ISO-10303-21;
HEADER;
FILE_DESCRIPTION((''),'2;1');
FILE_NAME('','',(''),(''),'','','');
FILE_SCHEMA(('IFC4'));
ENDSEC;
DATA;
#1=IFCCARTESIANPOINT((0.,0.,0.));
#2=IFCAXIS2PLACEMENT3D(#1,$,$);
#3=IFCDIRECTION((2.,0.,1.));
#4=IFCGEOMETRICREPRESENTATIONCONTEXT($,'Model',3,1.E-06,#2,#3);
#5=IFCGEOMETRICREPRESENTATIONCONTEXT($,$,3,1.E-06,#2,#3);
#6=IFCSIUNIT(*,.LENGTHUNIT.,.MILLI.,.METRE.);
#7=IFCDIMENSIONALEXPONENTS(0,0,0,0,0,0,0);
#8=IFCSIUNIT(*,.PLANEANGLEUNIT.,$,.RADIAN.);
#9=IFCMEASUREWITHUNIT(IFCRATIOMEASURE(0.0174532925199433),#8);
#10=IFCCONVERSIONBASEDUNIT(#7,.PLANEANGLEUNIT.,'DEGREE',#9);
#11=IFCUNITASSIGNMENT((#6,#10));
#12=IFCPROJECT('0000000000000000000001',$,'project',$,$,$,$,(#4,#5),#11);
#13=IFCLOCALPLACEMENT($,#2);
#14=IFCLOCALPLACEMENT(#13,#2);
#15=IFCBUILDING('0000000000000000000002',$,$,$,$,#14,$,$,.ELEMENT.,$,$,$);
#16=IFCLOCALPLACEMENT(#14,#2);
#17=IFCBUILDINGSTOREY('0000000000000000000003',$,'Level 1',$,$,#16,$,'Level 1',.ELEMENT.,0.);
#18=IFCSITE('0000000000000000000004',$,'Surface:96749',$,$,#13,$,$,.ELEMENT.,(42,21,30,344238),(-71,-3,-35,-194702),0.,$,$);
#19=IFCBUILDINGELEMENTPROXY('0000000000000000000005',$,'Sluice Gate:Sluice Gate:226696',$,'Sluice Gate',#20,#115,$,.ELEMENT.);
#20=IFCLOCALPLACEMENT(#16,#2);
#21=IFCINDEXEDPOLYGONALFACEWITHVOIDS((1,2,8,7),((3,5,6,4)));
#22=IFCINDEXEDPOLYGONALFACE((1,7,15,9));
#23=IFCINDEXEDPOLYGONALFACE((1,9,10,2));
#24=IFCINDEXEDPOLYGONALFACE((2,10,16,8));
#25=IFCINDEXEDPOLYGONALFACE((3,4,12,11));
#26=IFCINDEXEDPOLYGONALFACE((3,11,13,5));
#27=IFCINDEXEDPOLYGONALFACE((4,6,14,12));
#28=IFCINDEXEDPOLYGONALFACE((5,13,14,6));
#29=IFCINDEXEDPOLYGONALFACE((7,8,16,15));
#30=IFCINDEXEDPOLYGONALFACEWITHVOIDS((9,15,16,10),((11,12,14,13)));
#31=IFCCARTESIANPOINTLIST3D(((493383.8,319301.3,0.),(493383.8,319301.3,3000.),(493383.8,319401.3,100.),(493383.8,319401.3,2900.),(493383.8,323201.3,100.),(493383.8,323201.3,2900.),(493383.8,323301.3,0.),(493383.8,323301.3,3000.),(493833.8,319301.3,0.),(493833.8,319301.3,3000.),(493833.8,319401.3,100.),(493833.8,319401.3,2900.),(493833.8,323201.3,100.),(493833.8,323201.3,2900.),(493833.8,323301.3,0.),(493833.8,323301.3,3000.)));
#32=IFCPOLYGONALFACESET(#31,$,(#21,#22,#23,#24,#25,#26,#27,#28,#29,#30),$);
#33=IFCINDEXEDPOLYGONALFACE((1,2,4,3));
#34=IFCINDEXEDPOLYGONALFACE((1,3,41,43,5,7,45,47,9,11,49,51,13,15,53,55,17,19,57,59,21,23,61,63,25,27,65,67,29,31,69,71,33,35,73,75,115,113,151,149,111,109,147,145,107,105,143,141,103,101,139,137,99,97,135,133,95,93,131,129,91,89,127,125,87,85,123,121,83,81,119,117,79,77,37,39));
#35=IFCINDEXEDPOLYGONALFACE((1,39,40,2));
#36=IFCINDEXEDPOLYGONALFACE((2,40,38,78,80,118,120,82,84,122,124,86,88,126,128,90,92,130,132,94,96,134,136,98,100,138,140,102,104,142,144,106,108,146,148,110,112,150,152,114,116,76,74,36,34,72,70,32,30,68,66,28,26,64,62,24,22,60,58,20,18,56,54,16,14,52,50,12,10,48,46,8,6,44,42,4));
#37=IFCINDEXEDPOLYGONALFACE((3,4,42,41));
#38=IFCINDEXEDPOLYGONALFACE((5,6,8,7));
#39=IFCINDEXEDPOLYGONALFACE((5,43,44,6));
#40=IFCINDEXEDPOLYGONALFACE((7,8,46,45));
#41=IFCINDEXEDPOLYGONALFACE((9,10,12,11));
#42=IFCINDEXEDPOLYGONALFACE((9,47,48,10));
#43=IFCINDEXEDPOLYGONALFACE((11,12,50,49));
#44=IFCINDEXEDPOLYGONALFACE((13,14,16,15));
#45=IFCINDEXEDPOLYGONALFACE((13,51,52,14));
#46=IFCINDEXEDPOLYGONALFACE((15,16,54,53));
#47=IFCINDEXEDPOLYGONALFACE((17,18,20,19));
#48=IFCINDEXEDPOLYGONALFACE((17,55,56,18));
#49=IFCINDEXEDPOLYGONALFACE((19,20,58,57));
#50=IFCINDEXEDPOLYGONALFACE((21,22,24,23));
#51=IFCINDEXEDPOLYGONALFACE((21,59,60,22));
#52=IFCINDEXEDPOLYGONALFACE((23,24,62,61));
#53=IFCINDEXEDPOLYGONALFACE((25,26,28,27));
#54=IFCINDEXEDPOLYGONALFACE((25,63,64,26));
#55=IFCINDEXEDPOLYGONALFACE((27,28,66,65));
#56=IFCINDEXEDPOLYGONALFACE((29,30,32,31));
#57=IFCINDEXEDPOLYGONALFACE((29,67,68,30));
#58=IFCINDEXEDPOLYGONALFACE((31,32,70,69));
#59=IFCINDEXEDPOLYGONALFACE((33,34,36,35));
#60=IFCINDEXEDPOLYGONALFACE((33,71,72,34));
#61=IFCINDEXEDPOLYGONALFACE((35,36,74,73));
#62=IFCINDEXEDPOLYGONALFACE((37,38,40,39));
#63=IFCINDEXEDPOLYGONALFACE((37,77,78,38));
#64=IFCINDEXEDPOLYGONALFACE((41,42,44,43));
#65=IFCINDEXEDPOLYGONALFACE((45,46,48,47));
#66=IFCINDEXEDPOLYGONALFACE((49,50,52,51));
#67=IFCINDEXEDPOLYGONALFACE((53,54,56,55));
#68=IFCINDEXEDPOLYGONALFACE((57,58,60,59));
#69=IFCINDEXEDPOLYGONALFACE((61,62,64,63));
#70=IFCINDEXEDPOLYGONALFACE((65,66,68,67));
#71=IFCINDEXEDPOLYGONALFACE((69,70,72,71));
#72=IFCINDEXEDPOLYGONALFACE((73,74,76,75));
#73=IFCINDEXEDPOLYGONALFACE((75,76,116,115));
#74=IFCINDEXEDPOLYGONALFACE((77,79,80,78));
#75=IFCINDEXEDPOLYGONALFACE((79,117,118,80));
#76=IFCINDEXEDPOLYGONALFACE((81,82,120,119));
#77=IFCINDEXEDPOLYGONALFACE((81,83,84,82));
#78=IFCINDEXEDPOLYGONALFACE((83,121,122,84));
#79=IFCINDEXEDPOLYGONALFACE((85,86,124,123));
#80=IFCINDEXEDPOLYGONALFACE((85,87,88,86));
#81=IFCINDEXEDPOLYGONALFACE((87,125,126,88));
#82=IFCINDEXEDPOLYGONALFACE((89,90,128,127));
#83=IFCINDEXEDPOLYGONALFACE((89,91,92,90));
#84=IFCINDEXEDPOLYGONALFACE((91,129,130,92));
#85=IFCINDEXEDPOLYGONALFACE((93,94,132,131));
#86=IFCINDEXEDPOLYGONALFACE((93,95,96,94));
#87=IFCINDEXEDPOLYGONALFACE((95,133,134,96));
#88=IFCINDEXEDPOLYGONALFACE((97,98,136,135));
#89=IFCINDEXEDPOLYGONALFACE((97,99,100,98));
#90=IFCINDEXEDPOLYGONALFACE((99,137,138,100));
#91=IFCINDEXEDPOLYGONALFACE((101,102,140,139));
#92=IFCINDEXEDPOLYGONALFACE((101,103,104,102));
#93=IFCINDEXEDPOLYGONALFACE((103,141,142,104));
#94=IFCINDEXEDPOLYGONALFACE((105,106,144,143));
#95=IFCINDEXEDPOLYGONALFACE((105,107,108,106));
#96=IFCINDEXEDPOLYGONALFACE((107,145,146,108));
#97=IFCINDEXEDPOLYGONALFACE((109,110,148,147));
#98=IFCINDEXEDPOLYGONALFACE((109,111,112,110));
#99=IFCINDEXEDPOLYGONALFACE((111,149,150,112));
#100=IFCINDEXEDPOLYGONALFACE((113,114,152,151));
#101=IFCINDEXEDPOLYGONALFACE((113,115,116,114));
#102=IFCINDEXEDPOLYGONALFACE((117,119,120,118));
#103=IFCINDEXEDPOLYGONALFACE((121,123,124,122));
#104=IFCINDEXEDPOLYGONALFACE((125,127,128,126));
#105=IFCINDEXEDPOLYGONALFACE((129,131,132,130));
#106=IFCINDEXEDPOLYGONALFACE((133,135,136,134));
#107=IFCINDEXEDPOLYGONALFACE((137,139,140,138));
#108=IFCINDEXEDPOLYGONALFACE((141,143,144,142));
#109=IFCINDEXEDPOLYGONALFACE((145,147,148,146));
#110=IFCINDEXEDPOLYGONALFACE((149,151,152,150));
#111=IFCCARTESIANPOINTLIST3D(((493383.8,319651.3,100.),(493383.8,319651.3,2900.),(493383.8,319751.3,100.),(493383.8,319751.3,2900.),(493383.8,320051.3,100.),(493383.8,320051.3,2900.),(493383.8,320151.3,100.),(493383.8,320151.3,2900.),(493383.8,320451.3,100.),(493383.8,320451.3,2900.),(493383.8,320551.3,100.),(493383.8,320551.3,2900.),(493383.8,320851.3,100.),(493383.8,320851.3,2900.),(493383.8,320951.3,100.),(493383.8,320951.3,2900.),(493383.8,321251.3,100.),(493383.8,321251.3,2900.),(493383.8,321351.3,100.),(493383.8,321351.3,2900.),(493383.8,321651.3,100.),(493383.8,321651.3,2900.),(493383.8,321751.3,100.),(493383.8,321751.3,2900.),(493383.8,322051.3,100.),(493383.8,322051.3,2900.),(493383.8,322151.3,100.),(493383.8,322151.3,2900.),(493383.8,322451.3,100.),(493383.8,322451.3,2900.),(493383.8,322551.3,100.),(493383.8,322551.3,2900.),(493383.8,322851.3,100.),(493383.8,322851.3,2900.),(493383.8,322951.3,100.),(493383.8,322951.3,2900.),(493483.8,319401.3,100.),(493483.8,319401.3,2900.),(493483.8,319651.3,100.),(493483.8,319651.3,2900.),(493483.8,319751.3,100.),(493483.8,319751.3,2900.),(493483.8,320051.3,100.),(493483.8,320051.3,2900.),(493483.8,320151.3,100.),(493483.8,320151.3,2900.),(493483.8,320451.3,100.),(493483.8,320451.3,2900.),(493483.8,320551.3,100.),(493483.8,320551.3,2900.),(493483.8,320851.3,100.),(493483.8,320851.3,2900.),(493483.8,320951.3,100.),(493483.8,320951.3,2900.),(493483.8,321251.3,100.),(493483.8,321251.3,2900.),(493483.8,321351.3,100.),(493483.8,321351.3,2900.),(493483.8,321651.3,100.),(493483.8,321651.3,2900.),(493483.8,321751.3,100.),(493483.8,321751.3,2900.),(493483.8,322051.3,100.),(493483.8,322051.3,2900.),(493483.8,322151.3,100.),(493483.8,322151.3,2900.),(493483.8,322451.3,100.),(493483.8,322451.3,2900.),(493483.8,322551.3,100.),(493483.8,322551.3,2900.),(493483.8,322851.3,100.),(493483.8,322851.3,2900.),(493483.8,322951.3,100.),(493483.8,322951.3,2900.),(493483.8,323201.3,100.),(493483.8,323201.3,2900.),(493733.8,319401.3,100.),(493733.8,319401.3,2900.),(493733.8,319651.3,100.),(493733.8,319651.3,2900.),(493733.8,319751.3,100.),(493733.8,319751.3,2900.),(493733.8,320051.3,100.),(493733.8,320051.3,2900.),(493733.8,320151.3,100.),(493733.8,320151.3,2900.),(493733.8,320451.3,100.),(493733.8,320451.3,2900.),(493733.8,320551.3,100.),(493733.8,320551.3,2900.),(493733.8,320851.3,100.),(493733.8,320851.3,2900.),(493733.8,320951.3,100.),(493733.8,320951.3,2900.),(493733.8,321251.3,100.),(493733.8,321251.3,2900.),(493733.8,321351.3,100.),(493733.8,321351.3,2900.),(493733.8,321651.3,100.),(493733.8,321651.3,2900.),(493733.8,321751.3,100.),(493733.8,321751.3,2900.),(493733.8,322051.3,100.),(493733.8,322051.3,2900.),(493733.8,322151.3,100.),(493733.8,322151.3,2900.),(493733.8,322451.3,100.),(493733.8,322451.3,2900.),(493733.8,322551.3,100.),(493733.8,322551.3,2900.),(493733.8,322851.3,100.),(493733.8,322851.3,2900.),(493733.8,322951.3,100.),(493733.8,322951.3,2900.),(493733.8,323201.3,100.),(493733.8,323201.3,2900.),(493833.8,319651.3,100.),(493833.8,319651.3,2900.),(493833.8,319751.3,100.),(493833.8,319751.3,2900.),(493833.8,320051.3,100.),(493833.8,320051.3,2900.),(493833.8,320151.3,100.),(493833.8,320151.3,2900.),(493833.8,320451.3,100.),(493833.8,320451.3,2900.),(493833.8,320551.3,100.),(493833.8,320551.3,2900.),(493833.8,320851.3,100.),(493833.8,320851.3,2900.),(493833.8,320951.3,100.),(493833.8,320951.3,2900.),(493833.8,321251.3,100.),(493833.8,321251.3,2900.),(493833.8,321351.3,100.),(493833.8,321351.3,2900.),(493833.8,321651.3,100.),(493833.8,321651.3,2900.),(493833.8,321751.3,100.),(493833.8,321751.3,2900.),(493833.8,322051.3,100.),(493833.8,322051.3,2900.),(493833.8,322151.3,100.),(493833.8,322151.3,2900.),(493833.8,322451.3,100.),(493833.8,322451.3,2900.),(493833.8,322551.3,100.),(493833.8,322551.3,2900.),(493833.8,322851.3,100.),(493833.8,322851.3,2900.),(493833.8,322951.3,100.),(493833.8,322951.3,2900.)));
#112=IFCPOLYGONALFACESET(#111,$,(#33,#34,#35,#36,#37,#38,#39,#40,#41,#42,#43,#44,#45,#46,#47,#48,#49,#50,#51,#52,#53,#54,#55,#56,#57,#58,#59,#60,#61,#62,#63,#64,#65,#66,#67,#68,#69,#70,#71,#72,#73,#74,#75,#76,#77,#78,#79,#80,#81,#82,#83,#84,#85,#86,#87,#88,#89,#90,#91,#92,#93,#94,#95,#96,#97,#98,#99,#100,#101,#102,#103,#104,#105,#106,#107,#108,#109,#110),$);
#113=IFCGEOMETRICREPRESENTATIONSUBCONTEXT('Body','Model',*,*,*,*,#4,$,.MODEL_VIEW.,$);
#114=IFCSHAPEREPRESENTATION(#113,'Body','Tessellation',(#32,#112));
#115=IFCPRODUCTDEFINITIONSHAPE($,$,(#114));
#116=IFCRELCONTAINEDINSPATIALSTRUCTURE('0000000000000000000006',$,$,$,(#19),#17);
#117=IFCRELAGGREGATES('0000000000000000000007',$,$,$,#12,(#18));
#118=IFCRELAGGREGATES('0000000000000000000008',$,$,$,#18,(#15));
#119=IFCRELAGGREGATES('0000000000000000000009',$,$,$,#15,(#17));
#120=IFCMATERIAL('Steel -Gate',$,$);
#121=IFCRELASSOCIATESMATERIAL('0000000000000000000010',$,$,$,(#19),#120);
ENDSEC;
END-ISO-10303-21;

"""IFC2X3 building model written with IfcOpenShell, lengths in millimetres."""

from ifc_helpers import new_model, entity, si_unit, converted_unit, direction, frame, origin, place, context, subcontext, project, spatial, polyline, outline, extrude, source, transform, mapped, material, element, save


model = new_model("IFC2X3")

# Units and contexts
model_context = context("Model", 3, precision=1e-06, world=origin(), true_north=direction((2.0, 0.0, 1.0)))
context_of_model = context(None, 3, precision=1e-06, world=origin(), true_north=direction((2.0, 0.0, 1.0)))
body_context = subcontext(model_context, "Body", "Model", "MODEL_VIEW")
ifc_project = project(units=[si_unit("LENGTHUNIT", "METRE", prefix="MILLI"), converted_unit("PLANEANGLEUNIT", "DEGREE", entity("IfcRatioMeasure", 0.0174532925199433), si_unit("PLANEANGLEUNIT", "RADIAN"), dimensions=[0, 0, 0, 0, 0, 0, 0])], contexts=[model_context, context_of_model])

# Site, building, storey
site_placement = place(None, origin())
site = spatial("IfcSite", under=ifc_project, at=site_placement, Name="Surface:96749", CompositionType="ELEMENT", RefLatitude=(42, 21, 30, 344238), RefLongitude=(-71, -3, -35, -194702), RefElevation=0.0)
building_placement = place(site_placement, origin())
building = spatial("IfcBuilding", under=site, at=building_placement, CompositionType="ELEMENT")
storey_placement = place(building_placement, origin())
storey = spatial("IfcBuildingStorey", under=building, at=storey_placement, Name="Level 1", LongName="Level 1", CompositionType="ELEMENT", Elevation=0.0)

# Building element proxy
ifc_material = material(Name="Steel -Gate")
shared_shape_1 = source(origin(), body_context, "Body", "SweptSolid", [
    extrude(outline(polyline([(-2000.0, -1500.0), (2000.0, -1500.0), (2000.0, 1500.0), (-2000.0, 1500.0), (-2000.0, -1500.0)]), holes=[polyline([(-1900.0, 1400.0), (1900.0, 1400.0), (1900.0, -1400.0), (-1900.0, -1400.0), (-1900.0, 1400.0)])]), frame((0.0, -225.0, 1500.0), z_axis=(0.0, 1.0, 0.0), x_axis=(-1.0, 0.0, 0.0)), (0.0, 0.0, 1.0), 450.0),
    extrude(outline(polyline([(125.0, -1650.0), (225.0, -1650.0), (225.0, -1550.0), (125.0, -1550.0), (125.0, -1250.0), (225.0, -1250.0), (225.0, -1150.0), (125.0, -1150.0), (125.0, -850.0), (225.0, -850.0), (225.0, -750.0), (125.0, -750.0), (125.0, -450.0), (225.0, -450.0), (225.0, -350.0), (125.0, -350.0), (125.0, -50.0), (225.0, -50.0), (225.0, 50.0), (125.0, 50.0), (125.0, 350.0), (225.0, 350.0), (225.0, 450.0), (125.0, 450.0), (125.0, 750.0), (225.0, 750.0), (225.0, 850.0), (125.0, 850.0), (125.0, 1150.0), (225.0, 1150.0), (225.0, 1250.0), (125.0, 1250.0), (125.0, 1550.0), (225.0, 1550.0), (225.0, 1650.0), (125.0, 1650.0), (125.0, 1900.0), (-125.0, 1900.0), (-125.0, 1650.0), (-225.0, 1650.0), (-225.0, 1550.0), (-125.0, 1550.0), (-125.0, 1250.0), (-225.0, 1250.0), (-225.0, 1150.0), (-125.0, 1150.0), (-125.0, 850.0), (-225.0, 850.0), (-225.0, 750.0), (-125.0, 750.0), (-125.0, 450.0), (-225.0, 450.0), (-225.0, 350.0), (-125.0, 350.0), (-125.0, 50.0), (-225.0, 50.0), (-225.0, -50.0), (-125.0, -50.0), (-125.0, -350.0), (-225.0, -350.0), (-225.0, -450.0), (-125.0, -450.0), (-125.0, -750.0), (-225.0, -750.0), (-225.0, -850.0), (-125.0, -850.0), (-125.0, -1150.0), (-225.0, -1150.0), (-225.0, -1250.0), (-125.0, -1250.0), (-125.0, -1550.0), (-225.0, -1550.0), (-225.0, -1650.0), (-125.0, -1650.0), (-125.0, -1900.0), (125.0, -1900.0), (125.0, -1650.0)])), frame((0.0, 0.0, 100.0), z_axis=(0.0, 0.0, 1.0), x_axis=(0.0, -1.0, 0.0)), (0.0, 0.0, 1.0), 2800.0),
])
for number, where, z_axis, x_axis, name in (
    (1, (493608.8, 321301.3, 0.0), (0.0, 0.0, 1.0), (0.0, 1.0, 0.0), "Sluice Gate:Sluice Gate:226696"),
):
    element("IfcBuildingElementProxy", number, at=place(storey_placement, frame(where, z_axis=z_axis, x_axis=x_axis)), inside=storey, material=ifc_material, Name=name, ObjectType="Sluice Gate", CompositionType="ELEMENT", context=body_context, shape_type="MappedRepresentation", body=[
        mapped(shared_shape_1, transform((0.0, 0.0, 0.0), scale=1.0)),
    ])

save(model, "model.ifc")
